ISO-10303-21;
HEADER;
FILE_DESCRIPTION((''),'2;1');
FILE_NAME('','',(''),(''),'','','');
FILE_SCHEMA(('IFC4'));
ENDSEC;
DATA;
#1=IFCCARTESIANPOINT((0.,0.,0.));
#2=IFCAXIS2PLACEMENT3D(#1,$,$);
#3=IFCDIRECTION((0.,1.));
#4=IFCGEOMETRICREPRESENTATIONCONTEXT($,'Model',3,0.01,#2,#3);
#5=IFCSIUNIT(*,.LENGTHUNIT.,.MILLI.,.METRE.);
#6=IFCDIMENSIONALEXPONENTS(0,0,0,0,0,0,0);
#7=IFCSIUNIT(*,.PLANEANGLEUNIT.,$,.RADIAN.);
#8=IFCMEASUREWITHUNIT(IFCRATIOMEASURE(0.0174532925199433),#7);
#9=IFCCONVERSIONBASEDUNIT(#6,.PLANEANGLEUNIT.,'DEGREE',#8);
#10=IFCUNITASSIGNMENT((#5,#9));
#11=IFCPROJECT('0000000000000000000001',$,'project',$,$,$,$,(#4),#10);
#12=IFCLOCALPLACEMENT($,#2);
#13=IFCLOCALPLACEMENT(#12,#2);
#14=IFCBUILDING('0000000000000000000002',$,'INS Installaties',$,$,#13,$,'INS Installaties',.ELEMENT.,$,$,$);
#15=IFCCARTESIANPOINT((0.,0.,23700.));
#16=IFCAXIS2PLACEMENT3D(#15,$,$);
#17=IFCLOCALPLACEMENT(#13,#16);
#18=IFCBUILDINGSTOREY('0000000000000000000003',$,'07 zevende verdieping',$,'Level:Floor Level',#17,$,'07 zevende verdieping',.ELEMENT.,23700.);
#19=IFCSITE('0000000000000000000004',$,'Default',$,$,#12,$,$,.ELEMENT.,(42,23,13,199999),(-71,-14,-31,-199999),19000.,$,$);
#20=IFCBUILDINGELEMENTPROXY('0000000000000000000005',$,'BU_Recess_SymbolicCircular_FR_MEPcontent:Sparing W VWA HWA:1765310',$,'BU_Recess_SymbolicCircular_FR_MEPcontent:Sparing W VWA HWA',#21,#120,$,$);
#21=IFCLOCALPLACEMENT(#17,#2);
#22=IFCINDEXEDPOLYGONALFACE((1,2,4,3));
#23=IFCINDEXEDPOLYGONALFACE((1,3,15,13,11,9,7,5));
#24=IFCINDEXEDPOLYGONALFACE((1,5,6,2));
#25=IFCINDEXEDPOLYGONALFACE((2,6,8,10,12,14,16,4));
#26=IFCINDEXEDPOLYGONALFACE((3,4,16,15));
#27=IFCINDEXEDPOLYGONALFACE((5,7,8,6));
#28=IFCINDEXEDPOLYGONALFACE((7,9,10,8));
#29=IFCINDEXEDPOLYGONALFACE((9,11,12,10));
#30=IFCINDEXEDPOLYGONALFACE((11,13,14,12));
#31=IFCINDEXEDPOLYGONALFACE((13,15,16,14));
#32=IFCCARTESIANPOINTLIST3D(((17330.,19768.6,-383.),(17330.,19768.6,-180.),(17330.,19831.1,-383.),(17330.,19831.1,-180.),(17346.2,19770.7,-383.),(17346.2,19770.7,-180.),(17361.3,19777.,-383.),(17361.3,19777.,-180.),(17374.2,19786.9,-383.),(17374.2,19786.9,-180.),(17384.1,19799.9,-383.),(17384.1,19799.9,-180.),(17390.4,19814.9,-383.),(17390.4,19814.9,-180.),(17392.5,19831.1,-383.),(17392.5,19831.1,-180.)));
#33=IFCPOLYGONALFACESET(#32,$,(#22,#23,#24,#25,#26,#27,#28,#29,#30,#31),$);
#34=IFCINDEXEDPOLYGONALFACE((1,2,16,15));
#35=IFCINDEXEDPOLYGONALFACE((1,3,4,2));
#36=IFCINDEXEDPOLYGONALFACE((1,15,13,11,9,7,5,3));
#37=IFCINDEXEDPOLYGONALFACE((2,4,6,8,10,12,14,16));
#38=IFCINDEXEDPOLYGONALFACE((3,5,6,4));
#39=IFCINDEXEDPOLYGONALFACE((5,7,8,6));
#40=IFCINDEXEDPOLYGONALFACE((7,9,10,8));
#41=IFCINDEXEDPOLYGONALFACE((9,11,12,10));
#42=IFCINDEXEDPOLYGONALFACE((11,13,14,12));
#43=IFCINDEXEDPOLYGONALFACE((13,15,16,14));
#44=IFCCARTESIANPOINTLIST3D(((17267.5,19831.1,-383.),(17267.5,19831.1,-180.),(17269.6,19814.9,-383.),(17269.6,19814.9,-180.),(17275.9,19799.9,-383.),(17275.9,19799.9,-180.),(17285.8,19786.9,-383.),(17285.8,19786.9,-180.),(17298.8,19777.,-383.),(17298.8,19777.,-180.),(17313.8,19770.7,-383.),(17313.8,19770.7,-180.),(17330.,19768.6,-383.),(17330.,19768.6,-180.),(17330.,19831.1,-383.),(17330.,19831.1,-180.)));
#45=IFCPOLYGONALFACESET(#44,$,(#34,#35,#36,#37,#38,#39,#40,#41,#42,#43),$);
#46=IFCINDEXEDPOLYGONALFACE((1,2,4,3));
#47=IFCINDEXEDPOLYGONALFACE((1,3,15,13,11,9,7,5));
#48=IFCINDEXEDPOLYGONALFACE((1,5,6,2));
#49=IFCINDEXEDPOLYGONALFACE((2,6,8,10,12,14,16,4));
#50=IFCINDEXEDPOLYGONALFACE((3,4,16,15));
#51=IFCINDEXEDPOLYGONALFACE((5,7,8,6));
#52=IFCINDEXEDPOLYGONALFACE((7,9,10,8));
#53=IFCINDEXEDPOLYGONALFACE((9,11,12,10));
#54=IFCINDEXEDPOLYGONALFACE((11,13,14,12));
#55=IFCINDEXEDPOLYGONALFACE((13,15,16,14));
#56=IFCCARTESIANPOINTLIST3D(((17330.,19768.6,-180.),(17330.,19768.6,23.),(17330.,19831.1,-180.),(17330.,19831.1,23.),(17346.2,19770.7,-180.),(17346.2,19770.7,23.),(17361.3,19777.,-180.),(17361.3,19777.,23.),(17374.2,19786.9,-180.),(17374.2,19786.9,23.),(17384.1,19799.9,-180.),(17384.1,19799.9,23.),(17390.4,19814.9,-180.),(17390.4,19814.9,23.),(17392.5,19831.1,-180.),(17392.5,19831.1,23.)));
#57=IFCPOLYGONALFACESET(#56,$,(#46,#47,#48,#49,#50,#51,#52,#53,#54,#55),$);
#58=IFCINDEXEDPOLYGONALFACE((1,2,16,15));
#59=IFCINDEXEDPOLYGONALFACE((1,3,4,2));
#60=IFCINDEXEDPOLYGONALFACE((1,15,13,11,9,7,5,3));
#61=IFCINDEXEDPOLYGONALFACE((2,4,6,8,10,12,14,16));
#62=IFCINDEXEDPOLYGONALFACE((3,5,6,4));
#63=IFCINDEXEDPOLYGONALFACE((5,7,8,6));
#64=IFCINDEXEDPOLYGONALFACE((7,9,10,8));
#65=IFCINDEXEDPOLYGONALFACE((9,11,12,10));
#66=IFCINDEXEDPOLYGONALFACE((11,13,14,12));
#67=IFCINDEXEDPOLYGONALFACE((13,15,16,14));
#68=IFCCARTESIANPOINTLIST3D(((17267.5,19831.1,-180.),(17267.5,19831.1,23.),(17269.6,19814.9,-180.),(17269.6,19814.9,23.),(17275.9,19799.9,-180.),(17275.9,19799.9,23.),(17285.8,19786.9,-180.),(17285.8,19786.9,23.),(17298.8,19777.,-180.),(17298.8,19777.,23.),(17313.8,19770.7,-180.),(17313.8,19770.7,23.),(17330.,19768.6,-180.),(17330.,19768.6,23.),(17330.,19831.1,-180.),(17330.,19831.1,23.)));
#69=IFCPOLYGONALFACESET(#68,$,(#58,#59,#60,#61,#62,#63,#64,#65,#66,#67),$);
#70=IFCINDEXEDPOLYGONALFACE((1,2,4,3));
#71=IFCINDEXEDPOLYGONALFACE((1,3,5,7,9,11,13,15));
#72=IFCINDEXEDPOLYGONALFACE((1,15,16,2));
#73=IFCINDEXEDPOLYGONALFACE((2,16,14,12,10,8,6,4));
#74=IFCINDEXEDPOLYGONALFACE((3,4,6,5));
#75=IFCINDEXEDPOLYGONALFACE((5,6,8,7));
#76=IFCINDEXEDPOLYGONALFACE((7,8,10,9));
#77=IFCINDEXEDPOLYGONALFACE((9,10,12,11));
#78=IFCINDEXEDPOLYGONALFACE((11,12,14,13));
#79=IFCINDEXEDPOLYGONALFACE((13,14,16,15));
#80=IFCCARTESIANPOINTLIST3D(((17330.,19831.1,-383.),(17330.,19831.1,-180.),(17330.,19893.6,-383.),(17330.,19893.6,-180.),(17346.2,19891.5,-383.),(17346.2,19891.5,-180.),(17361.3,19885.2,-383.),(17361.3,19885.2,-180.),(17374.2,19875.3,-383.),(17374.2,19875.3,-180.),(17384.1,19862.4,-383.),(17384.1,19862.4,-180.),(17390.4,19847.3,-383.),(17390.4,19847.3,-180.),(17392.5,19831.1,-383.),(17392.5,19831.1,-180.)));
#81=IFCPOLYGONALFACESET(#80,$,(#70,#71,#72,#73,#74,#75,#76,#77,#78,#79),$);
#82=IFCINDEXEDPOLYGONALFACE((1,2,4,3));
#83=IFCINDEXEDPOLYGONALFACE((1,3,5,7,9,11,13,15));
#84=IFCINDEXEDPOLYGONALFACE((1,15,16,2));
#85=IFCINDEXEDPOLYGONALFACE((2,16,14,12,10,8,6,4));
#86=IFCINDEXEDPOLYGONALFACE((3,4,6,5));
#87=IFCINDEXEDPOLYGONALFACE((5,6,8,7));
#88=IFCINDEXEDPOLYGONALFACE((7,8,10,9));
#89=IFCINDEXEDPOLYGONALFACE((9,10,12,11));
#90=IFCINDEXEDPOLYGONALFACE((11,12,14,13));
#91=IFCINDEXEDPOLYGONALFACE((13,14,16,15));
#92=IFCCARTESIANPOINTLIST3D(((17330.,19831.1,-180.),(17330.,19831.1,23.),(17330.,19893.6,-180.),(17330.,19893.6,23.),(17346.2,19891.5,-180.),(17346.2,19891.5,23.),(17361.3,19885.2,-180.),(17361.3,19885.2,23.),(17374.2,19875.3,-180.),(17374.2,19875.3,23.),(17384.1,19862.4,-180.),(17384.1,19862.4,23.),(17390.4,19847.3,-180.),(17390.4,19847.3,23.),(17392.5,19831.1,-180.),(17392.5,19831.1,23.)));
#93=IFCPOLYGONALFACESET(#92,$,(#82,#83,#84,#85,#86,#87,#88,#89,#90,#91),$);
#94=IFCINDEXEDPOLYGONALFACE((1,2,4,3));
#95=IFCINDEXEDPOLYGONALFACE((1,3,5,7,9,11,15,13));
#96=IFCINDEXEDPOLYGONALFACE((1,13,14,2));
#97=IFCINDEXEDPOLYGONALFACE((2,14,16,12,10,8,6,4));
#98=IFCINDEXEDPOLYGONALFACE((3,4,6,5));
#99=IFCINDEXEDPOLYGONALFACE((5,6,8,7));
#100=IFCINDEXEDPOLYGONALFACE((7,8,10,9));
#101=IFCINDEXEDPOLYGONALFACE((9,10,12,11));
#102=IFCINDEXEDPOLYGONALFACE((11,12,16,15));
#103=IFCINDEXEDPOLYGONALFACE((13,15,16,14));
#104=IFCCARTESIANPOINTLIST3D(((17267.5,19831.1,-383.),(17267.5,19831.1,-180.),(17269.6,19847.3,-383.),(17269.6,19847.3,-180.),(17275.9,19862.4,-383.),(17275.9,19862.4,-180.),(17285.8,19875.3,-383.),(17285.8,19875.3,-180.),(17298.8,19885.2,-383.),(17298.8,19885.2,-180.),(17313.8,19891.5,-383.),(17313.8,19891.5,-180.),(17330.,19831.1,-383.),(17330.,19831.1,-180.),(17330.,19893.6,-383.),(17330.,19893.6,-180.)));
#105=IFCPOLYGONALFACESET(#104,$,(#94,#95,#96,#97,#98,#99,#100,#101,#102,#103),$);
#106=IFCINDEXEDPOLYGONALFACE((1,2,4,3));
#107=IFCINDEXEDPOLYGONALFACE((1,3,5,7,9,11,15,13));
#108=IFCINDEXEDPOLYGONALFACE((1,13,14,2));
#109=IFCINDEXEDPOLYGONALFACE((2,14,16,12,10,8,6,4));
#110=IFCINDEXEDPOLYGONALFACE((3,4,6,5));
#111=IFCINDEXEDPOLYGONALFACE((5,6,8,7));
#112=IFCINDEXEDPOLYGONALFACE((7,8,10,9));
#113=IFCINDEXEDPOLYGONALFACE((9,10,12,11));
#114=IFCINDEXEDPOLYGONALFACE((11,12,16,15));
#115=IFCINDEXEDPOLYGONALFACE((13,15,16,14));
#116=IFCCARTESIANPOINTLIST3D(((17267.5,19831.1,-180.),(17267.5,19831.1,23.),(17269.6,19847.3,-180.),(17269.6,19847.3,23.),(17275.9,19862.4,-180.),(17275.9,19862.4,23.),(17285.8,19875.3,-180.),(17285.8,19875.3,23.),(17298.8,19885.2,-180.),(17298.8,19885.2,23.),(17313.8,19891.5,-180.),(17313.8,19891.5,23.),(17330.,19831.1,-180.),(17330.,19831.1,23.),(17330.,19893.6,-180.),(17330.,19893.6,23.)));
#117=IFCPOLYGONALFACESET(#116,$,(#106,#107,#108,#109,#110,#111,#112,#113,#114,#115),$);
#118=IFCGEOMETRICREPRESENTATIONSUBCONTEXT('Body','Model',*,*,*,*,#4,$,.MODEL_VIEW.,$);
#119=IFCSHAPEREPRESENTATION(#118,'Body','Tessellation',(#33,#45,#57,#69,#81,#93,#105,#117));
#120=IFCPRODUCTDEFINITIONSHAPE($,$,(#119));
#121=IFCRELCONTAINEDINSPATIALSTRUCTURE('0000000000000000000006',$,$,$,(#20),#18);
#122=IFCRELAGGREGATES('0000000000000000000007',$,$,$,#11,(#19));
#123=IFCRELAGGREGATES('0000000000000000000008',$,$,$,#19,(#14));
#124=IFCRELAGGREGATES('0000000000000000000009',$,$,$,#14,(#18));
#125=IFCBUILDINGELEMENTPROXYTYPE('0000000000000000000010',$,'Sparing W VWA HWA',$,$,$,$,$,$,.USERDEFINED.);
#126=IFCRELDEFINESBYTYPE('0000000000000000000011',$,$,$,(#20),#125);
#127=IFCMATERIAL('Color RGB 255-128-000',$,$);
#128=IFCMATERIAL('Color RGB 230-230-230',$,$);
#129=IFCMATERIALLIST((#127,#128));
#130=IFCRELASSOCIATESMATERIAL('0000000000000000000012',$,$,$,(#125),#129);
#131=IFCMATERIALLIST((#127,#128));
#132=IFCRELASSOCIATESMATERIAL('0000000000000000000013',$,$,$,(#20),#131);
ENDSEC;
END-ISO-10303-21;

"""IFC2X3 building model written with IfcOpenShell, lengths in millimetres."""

from ifc_helpers import new_model, entity, si_unit, converted_unit, direction, frame, frame_2d, origin, place, context, subcontext, project, spatial, polyline, circle_curve, parameter, trimmed, segment, composite_curve, outline, extrude, source, transform, mapped, material, material_list, type_object, type_shapes, element, save


model = new_model("IFC2X3")

# Units and contexts
model_context = context("Model", 3, precision=0.01, world=origin(), true_north=direction((0.0, 1.0)))
body_context = subcontext(model_context, "Body", "Model", "MODEL_VIEW")
ifc_project = project(units=[si_unit("LENGTHUNIT", "METRE", prefix="MILLI"), converted_unit("PLANEANGLEUNIT", "DEGREE", entity("IfcRatioMeasure", 0.0174532925199433), si_unit("PLANEANGLEUNIT", "RADIAN"), dimensions=[0, 0, 0, 0, 0, 0, 0])], contexts=[model_context])

# Site, building, storey
site_placement = place(None, origin())
site = spatial("IfcSite", under=ifc_project, at=site_placement, Name="Default", CompositionType="ELEMENT", RefLatitude=(42, 23, 13, 199999), RefLongitude=(-71, -14, -31, -199999), RefElevation=19000.0)
building_placement = place(site_placement, origin())
building = spatial("IfcBuilding", under=site, at=building_placement, Name="INS Installaties", LongName="INS Installaties", CompositionType="ELEMENT")
storey_placement = place(building_placement, frame((0.0, 0.0, 23700.0)))
storey = spatial("IfcBuildingStorey", under=building, at=storey_placement, Name="07 zevende verdieping", ObjectType="Level:Floor Level", LongName="07 zevende verdieping", CompositionType="ELEMENT", Elevation=23700.0)

# Building element proxy
ifc_material_1 = material(Name="Color RGB 255-128-000")
ifc_material_2 = material(Name="Color RGB 230-230-230")
ifc_material_list_1 = material_list([ifc_material_1, ifc_material_2])
building_element_proxy_type_1 = type_object("IfcBuildingElementProxyType", Name="Sparing W VWA HWA", PredefinedType="USERDEFINED", material=ifc_material_list_1)
shared_shape_1 = source(origin(), body_context, "Body", "SweptSolid", [
    extrude(outline(composite_curve([segment(polyline([(-41.7, -20.8), (20.8, -20.8)]), True, "CONTINUOUS"), segment(polyline([(20.8, -20.8), (20.8, 41.7)]), True, "CONTINUOUS"), segment(trimmed(circle_curve(frame_2d((20.8, -20.8), x_axis=(1.0, 0.0)), 62.5), [parameter(90.0)], [parameter(180.0)], True, "PARAMETER"), True, "CONTINUOUS")], self_intersect=False)), frame((20.8, -20.8, -403.0), z_axis=(0.0, 0.0, 1.0), x_axis=(-1.0, 0.0, 0.0)), (0.0, 0.0, 1.0), 203.0),
    extrude(outline(composite_curve([segment(trimmed(circle_curve(frame_2d((20.8, 20.8), x_axis=(1.0, 0.0)), 62.5), [parameter(180.0)], [parameter(270.0)], True, "PARAMETER"), True, "CONTINUOUS"), segment(polyline([(20.8, -41.7), (20.8, 20.8)]), True, "CONTINUOUS"), segment(polyline([(20.8, 20.8), (-41.7, 20.8)]), True, "CONTINUOUS")], self_intersect=False)), frame((-20.8, -20.8, -403.0)), (0.0, 0.0, 1.0), 203.0),
    extrude(outline(composite_curve([segment(polyline([(-41.7, -20.8), (20.8, -20.8)]), True, "CONTINUOUS"), segment(polyline([(20.8, -20.8), (20.8, 41.7)]), True, "CONTINUOUS"), segment(trimmed(circle_curve(frame_2d((20.8, -20.8), x_axis=(1.0, 0.0)), 62.5), [parameter(90.0)], [parameter(180.0)], True, "PARAMETER"), True, "CONTINUOUS")], self_intersect=False)), frame((20.8, -20.8, -200.0), z_axis=(0.0, 0.0, 1.0), x_axis=(-1.0, 0.0, 0.0)), (0.0, 0.0, 1.0), 203.0),
    extrude(outline(composite_curve([segment(trimmed(circle_curve(frame_2d((20.8, 20.8), x_axis=(1.0, 0.0)), 62.5), [parameter(180.0)], [parameter(270.0)], True, "PARAMETER"), True, "CONTINUOUS"), segment(polyline([(20.8, -41.7), (20.8, 20.8)]), True, "CONTINUOUS"), segment(polyline([(20.8, 20.8), (-41.7, 20.8)]), True, "CONTINUOUS")], self_intersect=False)), frame((-20.8, -20.8, -200.0)), (0.0, 0.0, 1.0), 203.0),
    extrude(outline(composite_curve([segment(trimmed(circle_curve(frame_2d((20.8, 20.8), x_axis=(1.0, 0.0)), 62.5), [parameter(180.0)], [parameter(270.0)], True, "PARAMETER"), True, "CONTINUOUS"), segment(polyline([(20.8, -41.7), (20.8, 20.8)]), True, "CONTINUOUS"), segment(polyline([(20.8, 20.8), (-41.7, 20.8)]), True, "CONTINUOUS")], self_intersect=False)), frame((20.8, 20.8, -403.0), z_axis=(0.0, 0.0, 1.0), x_axis=(-1.0, 0.0, 0.0)), (0.0, 0.0, 1.0), 203.0),
    extrude(outline(composite_curve([segment(trimmed(circle_curve(frame_2d((20.8, 20.8), x_axis=(1.0, 0.0)), 62.5), [parameter(180.0)], [parameter(270.0)], True, "PARAMETER"), True, "CONTINUOUS"), segment(polyline([(20.8, -41.7), (20.8, 20.8)]), True, "CONTINUOUS"), segment(polyline([(20.8, 20.8), (-41.7, 20.8)]), True, "CONTINUOUS")], self_intersect=False)), frame((20.8, 20.8, -200.0), z_axis=(0.0, 0.0, 1.0), x_axis=(-1.0, 0.0, 0.0)), (0.0, 0.0, 1.0), 203.0),
    extrude(outline(composite_curve([segment(polyline([(-41.7, -20.8), (20.8, -20.8)]), True, "CONTINUOUS"), segment(polyline([(20.8, -20.8), (20.8, 41.7)]), True, "CONTINUOUS"), segment(trimmed(circle_curve(frame_2d((20.8, -20.8), x_axis=(1.0, 0.0)), 62.5), [parameter(90.0)], [parameter(180.0)], True, "PARAMETER"), True, "CONTINUOUS")], self_intersect=False)), frame((-20.8, 20.8, -403.0)), (0.0, 0.0, 1.0), 203.0),
    extrude(outline(composite_curve([segment(polyline([(-41.7, -20.8), (20.8, -20.8)]), True, "CONTINUOUS"), segment(polyline([(20.8, -20.8), (20.8, 41.7)]), True, "CONTINUOUS"), segment(trimmed(circle_curve(frame_2d((20.8, -20.8), x_axis=(1.0, 0.0)), 62.5), [parameter(90.0)], [parameter(180.0)], True, "PARAMETER"), True, "CONTINUOUS")], self_intersect=False)), frame((-20.8, 20.8, -200.0)), (0.0, 0.0, 1.0), 203.0),
])
type_shapes(building_element_proxy_type_1, [shared_shape_1])
ifc_material_list_2 = material_list([ifc_material_1, ifc_material_2])
proxy_1_placement = place(storey_placement, frame((17330.0, 19831.1, 20.0)))
element("IfcBuildingElementProxy", 1, at=proxy_1_placement, inside=storey, type_object=building_element_proxy_type_1, material=ifc_material_list_2, Name="BU_Recess_SymbolicCircular_FR_MEPcontent:Sparing W VWA HWA:1765310", ObjectType="BU_Recess_SymbolicCircular_FR_MEPcontent:Sparing W VWA HWA", context=body_context, shape_type="MappedRepresentation", body=[
    mapped(shared_shape_1, transform((0.0, 0.0, 0.0), scale=1.0)),
])

save(model, "model.ifc")
